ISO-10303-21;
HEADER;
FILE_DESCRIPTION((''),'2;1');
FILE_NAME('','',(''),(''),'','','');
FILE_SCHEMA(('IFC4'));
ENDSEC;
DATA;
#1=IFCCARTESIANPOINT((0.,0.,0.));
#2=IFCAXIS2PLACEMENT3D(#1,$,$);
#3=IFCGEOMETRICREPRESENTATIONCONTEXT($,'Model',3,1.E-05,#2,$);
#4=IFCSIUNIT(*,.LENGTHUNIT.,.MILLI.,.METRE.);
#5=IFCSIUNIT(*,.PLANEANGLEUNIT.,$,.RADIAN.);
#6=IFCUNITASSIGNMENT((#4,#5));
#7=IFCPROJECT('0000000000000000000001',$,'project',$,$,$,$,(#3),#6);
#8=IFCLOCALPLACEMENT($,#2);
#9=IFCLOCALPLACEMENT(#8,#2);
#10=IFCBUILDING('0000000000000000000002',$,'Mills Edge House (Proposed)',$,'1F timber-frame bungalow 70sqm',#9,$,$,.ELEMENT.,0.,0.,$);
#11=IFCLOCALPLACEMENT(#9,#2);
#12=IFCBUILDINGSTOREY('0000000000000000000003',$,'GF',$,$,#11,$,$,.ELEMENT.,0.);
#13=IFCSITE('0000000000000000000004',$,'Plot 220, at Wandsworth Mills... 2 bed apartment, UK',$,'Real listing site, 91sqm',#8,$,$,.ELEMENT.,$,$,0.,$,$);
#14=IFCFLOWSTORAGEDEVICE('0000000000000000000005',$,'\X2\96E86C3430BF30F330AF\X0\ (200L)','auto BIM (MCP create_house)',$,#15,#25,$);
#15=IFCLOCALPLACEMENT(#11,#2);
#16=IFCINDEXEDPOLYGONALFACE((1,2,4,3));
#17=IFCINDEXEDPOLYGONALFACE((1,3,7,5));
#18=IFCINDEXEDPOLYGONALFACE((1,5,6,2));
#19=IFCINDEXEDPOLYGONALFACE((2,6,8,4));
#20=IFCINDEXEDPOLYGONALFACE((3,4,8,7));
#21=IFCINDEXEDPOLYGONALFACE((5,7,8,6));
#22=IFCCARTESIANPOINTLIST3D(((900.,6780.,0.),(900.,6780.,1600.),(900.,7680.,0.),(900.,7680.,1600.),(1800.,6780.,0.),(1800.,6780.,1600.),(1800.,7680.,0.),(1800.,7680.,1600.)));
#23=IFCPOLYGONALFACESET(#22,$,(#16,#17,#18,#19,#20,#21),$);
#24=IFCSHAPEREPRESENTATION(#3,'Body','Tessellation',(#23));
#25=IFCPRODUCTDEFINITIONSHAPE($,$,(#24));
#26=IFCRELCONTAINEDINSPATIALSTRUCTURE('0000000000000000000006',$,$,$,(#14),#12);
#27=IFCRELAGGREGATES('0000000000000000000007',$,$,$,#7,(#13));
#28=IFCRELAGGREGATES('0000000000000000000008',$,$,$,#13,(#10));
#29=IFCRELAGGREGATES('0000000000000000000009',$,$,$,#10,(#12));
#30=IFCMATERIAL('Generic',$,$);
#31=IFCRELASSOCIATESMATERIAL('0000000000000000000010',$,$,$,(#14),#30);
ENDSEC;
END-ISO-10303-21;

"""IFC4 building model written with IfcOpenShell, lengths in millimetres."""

from ifc_helpers import new_model, si_unit, frame, frame_2d, origin, place, context, project, spatial, rectangle, extrude, material, element, save


model = new_model("IFC4")

# Units and contexts
model_context = context("Model", 3, precision=1e-05, world=origin())
ifc_project = project(units=[si_unit("LENGTHUNIT", "METRE", prefix="MILLI"), si_unit("PLANEANGLEUNIT", "RADIAN")], contexts=[model_context])

# Site, building, storey
site_placement = place(None, origin())
site = spatial("IfcSite", under=ifc_project, at=site_placement, Name="Plot 220, at Wandsworth Mills... 2 bed apartment, UK", ObjectType="Real listing site, 91sqm", CompositionType="ELEMENT", RefElevation=0.0)
building_placement = place(site_placement, origin())
building = spatial("IfcBuilding", under=site, at=building_placement, Name="Mills Edge House (Proposed)", ObjectType="1F timber-frame bungalow 70sqm", CompositionType="ELEMENT", ElevationOfRefHeight=0.0, ElevationOfTerrain=0.0)
storey_placement = place(building_placement, origin())
storey = spatial("IfcBuildingStorey", under=building, at=storey_placement, Name="GF", CompositionType="ELEMENT", Elevation=0.0)

# Shared definitions
ifc_material_1 = material(Name="Generic")

# Flow storage device
flow_storage_device_placement = place(storey_placement, frame((450.0, 3390.0, 0.0)))
element("IfcFlowStorageDevice", 1, at=flow_storage_device_placement, inside=storey, material=ifc_material_1, Name="雨水タンク (200L)", Description="auto BIM (MCP create_house)", context=model_context, shape_type="SweptSolid", body=[
    extrude(rectangle(XDim=900.0, YDim=900.0, at=frame_2d((450.0, 450.0))), frame((450.0, 3390.0, 0.0)), (0.0, 0.0, 1.0), 1600.0),
])

save(model, "model.ifc")
